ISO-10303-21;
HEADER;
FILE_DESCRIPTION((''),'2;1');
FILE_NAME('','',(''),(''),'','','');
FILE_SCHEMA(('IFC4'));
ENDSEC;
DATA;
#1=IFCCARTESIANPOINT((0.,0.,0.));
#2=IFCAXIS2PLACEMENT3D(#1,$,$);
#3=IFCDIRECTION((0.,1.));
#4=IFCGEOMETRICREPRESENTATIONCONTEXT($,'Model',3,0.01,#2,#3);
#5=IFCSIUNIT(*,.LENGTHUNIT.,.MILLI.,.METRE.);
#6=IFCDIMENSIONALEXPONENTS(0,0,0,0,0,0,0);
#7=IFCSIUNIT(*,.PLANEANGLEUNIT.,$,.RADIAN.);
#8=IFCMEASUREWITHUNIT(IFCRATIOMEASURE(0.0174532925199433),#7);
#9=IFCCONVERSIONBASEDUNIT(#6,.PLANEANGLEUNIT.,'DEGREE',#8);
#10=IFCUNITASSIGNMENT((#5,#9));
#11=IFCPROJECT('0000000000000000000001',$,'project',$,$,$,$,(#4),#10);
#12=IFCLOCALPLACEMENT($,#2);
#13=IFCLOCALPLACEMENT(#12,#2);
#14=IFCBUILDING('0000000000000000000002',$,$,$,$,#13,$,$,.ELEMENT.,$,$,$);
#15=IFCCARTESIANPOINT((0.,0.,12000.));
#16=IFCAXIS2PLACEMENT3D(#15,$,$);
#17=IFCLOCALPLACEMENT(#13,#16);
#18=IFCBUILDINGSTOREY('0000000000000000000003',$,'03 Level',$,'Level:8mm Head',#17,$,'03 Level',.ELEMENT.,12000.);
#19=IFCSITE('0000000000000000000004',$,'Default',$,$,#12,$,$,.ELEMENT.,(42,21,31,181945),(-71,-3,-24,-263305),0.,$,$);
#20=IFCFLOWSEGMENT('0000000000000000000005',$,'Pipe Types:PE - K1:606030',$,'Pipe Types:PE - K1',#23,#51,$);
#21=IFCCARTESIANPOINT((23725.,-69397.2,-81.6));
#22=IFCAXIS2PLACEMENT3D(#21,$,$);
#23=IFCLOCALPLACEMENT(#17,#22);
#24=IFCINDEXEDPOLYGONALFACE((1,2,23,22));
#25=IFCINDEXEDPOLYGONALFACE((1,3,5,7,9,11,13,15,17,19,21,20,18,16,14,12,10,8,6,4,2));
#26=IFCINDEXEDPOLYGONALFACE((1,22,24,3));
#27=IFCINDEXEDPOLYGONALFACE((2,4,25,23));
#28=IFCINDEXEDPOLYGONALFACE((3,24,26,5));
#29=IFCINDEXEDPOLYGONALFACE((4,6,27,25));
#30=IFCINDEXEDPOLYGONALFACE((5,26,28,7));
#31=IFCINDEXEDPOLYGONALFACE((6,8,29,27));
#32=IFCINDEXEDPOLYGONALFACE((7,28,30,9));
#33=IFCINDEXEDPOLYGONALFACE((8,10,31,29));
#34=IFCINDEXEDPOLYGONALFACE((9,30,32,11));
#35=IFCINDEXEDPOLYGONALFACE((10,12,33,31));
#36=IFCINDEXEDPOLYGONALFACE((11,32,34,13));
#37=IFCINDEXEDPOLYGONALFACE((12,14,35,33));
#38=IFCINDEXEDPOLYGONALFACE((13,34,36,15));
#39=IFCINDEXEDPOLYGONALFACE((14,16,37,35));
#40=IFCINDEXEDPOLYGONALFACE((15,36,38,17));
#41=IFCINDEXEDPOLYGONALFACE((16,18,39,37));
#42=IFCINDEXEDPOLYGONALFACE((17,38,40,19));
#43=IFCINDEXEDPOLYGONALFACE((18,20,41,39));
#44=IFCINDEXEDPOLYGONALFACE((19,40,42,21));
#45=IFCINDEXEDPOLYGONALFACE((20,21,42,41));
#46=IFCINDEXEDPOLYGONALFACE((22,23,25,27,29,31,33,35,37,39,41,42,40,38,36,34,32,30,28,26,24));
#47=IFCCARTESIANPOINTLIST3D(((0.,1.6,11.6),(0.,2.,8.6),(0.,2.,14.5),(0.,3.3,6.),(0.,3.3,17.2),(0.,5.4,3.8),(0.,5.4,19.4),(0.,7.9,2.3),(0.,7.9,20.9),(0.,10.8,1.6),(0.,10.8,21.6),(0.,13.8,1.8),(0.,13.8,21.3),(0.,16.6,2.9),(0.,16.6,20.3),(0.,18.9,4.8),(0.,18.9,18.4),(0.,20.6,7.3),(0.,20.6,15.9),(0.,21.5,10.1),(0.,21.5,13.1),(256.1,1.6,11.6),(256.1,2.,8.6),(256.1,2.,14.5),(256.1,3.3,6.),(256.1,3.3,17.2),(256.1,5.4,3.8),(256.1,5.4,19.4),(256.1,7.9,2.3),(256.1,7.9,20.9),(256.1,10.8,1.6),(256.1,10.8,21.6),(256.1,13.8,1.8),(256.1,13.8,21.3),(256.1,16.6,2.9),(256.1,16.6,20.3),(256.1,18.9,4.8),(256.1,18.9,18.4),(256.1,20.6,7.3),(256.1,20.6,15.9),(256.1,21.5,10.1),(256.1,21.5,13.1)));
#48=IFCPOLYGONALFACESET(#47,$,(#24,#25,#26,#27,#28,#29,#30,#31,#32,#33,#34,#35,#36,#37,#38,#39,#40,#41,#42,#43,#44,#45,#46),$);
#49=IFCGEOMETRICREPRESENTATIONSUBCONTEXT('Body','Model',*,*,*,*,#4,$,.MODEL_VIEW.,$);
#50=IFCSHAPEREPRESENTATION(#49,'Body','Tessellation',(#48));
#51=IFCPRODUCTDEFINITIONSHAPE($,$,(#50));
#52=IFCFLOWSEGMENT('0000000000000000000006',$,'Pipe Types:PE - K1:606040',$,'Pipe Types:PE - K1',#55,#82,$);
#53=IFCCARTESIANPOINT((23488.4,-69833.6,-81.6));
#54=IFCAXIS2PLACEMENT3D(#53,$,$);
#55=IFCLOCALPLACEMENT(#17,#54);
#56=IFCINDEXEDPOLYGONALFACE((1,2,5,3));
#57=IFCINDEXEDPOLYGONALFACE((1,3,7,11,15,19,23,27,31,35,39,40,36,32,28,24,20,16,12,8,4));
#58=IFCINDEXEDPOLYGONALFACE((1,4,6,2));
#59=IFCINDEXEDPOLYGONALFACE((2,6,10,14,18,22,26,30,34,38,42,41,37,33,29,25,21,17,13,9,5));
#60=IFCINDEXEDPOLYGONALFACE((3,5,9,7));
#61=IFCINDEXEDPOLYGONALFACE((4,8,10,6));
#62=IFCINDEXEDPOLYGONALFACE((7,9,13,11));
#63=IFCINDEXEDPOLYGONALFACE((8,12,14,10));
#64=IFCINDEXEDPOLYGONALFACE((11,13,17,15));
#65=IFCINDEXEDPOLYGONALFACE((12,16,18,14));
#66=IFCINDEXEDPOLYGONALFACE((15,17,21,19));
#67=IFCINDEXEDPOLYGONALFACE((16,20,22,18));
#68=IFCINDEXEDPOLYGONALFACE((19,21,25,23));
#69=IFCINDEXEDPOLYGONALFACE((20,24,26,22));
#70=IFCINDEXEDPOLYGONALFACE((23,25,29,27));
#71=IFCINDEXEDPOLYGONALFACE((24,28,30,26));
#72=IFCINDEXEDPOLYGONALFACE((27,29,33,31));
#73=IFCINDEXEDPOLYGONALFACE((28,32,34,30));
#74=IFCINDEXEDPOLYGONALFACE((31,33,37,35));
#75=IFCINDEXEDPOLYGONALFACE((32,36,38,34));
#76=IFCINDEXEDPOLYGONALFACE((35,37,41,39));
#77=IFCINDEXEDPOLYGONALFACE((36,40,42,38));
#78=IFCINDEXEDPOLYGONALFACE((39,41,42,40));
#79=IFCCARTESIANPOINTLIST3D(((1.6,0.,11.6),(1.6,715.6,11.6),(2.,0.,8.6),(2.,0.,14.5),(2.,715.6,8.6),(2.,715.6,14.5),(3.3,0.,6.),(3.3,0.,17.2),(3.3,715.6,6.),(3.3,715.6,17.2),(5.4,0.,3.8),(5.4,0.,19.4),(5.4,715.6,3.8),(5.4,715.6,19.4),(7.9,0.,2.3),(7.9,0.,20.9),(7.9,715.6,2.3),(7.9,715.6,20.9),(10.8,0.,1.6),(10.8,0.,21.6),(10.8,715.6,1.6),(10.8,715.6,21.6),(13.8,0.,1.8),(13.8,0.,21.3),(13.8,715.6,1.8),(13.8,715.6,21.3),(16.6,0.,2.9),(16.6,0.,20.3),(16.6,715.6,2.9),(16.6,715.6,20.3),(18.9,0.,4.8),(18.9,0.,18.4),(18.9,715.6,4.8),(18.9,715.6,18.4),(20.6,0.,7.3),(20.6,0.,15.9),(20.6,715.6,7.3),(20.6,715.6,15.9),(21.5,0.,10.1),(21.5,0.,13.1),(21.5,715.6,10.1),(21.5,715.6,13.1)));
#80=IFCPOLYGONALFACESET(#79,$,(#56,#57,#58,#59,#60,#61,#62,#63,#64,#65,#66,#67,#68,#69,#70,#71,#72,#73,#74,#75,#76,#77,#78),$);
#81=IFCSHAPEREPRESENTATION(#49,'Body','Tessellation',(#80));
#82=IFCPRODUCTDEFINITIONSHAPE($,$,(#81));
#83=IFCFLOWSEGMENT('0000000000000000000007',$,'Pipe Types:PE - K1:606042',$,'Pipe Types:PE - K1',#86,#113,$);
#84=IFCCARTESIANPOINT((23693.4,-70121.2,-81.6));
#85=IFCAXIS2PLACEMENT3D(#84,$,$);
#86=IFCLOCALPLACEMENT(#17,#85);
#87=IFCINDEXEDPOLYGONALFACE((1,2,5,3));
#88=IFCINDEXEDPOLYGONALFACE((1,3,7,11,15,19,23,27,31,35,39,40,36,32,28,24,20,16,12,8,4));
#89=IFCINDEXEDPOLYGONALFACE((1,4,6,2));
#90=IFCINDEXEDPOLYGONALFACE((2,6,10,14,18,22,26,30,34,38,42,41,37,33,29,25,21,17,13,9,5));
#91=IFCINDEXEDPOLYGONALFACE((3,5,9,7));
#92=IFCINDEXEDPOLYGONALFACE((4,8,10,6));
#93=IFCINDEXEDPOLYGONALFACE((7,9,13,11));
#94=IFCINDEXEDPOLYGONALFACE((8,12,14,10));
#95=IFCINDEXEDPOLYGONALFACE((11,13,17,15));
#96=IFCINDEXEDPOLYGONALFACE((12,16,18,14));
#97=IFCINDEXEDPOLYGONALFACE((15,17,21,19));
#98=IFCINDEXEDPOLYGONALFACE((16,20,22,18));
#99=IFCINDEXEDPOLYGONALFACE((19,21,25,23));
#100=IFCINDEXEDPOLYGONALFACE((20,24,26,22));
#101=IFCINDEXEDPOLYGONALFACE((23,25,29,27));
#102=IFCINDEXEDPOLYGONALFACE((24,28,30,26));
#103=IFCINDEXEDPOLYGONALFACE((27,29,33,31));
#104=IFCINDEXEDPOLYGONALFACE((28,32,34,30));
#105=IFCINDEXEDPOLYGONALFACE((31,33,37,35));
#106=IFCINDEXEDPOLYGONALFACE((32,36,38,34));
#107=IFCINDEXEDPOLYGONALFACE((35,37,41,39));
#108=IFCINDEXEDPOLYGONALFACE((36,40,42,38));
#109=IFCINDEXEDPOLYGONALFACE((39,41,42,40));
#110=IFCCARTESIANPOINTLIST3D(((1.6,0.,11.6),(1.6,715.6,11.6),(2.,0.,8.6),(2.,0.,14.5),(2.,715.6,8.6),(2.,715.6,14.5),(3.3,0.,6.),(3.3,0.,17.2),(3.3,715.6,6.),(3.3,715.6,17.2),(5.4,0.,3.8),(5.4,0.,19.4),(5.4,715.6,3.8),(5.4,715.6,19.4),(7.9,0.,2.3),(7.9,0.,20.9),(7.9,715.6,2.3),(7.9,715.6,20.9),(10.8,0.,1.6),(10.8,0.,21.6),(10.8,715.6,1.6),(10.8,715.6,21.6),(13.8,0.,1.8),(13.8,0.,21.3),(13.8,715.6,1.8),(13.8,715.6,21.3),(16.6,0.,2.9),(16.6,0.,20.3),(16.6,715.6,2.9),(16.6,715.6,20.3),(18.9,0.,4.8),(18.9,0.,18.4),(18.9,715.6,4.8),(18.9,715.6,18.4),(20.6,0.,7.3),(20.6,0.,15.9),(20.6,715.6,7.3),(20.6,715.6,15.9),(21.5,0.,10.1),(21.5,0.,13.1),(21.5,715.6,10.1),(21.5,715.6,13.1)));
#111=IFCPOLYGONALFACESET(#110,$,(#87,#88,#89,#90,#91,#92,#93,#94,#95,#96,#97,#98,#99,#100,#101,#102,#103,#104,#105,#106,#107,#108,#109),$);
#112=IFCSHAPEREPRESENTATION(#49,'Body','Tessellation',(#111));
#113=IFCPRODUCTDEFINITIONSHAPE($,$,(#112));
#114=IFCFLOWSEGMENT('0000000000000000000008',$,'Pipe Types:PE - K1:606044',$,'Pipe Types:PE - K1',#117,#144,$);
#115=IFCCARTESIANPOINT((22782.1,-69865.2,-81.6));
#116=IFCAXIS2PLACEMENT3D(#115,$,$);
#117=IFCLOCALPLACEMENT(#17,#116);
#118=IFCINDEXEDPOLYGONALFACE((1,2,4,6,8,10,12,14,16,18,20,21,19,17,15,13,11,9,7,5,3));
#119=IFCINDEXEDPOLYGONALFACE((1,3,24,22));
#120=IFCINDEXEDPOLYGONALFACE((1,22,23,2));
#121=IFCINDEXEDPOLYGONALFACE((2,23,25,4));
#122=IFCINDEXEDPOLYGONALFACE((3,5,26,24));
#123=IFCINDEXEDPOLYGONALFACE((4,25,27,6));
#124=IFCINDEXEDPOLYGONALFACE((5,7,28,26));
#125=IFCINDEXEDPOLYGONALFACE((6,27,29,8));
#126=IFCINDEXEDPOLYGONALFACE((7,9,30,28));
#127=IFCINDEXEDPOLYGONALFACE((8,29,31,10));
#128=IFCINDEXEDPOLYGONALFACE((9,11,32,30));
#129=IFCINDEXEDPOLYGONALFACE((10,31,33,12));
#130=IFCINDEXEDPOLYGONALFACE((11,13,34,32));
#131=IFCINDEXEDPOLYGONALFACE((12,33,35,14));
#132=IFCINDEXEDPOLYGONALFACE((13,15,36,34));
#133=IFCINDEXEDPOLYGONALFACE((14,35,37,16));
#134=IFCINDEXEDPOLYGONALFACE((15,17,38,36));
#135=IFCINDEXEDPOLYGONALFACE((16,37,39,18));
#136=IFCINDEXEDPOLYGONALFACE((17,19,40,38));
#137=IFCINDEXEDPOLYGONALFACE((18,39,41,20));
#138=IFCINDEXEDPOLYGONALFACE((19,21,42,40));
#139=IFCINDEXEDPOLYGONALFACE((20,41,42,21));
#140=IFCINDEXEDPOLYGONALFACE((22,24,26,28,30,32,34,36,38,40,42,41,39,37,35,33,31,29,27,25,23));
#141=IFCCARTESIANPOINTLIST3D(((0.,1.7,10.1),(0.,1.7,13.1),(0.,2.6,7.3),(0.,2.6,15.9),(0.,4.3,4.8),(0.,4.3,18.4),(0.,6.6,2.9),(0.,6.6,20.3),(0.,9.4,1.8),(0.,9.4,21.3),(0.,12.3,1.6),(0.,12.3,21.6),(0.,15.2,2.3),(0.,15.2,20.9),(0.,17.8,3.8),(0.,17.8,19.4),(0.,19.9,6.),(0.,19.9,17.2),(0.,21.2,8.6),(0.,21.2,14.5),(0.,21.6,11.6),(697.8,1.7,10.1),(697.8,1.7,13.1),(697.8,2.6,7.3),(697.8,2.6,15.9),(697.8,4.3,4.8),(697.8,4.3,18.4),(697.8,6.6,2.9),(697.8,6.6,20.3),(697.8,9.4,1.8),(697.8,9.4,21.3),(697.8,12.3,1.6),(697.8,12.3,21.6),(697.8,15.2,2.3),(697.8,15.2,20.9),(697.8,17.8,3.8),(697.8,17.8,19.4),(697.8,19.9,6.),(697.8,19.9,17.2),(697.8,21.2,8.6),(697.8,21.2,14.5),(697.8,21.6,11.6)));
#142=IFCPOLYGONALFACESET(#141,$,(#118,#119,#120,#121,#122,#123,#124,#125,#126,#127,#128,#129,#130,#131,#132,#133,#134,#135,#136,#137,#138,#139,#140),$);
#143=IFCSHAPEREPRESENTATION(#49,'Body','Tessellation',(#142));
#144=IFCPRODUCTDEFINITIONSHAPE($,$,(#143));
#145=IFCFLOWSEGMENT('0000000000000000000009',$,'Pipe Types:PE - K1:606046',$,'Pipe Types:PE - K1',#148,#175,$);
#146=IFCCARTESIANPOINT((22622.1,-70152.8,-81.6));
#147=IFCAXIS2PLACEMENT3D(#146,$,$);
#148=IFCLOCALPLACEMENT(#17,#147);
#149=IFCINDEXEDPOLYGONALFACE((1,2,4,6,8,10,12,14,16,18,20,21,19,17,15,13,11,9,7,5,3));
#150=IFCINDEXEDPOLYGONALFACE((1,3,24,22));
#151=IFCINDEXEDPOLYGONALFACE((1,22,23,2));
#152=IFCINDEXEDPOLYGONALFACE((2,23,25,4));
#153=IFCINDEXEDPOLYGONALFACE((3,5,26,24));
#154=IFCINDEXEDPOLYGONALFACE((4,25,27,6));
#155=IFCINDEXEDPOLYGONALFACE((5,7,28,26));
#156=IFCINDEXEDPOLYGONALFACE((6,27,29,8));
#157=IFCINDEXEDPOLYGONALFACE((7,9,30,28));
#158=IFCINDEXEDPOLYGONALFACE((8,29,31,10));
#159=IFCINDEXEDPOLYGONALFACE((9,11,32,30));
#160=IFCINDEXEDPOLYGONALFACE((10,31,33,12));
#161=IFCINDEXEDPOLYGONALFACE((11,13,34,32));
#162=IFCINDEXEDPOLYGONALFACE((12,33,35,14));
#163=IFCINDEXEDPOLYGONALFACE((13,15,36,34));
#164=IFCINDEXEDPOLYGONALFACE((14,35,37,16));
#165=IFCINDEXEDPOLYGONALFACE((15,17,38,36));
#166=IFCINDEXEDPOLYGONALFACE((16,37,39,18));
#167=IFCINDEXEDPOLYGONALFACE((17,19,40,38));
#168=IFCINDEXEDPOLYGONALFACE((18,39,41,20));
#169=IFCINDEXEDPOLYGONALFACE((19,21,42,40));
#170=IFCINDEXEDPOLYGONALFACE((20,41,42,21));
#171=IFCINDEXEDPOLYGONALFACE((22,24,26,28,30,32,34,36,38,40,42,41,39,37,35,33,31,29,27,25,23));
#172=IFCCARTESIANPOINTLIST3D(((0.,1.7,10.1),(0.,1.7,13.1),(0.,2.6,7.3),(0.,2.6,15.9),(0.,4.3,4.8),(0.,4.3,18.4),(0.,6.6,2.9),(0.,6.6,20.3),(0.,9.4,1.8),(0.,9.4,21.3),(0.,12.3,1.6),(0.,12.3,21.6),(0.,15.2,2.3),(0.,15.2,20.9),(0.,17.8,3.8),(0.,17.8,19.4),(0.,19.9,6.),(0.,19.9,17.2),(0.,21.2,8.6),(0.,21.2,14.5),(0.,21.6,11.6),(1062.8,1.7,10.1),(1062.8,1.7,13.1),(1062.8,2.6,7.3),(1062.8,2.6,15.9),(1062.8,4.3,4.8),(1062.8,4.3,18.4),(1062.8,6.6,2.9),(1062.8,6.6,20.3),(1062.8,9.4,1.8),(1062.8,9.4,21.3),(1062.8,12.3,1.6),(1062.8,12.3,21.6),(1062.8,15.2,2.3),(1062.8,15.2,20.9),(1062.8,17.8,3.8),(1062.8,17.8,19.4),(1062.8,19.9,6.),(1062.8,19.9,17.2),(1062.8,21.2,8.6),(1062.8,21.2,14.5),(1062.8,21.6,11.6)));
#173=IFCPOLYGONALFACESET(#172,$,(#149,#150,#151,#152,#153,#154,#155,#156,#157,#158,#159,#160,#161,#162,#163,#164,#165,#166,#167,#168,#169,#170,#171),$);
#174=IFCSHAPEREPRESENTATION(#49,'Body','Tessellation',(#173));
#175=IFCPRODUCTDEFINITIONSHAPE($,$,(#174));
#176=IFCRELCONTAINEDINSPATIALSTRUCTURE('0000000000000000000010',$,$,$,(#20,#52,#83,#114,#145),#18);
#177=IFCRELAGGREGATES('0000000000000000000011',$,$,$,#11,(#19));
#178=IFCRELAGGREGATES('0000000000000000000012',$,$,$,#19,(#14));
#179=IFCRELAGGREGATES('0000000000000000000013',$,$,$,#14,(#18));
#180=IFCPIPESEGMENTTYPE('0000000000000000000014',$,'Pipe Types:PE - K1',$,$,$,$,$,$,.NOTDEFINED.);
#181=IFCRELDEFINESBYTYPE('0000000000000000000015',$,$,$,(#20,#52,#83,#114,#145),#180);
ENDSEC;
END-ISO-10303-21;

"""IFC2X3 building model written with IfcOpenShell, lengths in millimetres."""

from ifc_helpers import new_model, entity, si_unit, converted_unit, direction, frame, frame_2d, origin, place, context, subcontext, project, spatial, circle, extrude, type_object, element, save


model = new_model("IFC2X3")

# Units and contexts
model_context = context("Model", 3, precision=0.01, world=origin(), true_north=direction((0.0, 1.0)))
body_context = subcontext(model_context, "Body", "Model", "MODEL_VIEW")
ifc_project = project(units=[si_unit("LENGTHUNIT", "METRE", prefix="MILLI"), converted_unit("PLANEANGLEUNIT", "DEGREE", entity("IfcRatioMeasure", 0.0174532925199433), si_unit("PLANEANGLEUNIT", "RADIAN"), dimensions=[0, 0, 0, 0, 0, 0, 0])], contexts=[model_context])

# Site, building, storey
site_placement = place(None, origin())
site = spatial("IfcSite", under=ifc_project, at=site_placement, Name="Default", CompositionType="ELEMENT", RefLatitude=(42, 21, 31, 181945), RefLongitude=(-71, -3, -24, -263305), RefElevation=0.0)
building_placement = place(site_placement, origin())
building = spatial("IfcBuilding", under=site, at=building_placement, CompositionType="ELEMENT")
storey_placement = place(building_placement, frame((0.0, 0.0, 12000.0)))
storey = spatial("IfcBuildingStorey", under=building, at=storey_placement, Name="03 Level", ObjectType="Level:8mm Head", LongName="03 Level", CompositionType="ELEMENT", Elevation=12000.0)

# Flow segments
pipe_segment_type = type_object("IfcPipeSegmentType", Name="Pipe Types:PE - K1", PredefinedType="NOTDEFINED")
flow_segment_1_placement = place(storey_placement, frame((23725.0, -69397.2, -81.6)))
element("IfcFlowSegment", 1, at=flow_segment_1_placement, inside=storey, type_object=pipe_segment_type, Name="Pipe Types:PE - K1:606030", ObjectType="Pipe Types:PE - K1", context=body_context, shape_type="SweptSolid", body=[
    extrude(circle(Radius=10.0, at=frame_2d((0.0, 0.0), x_axis=(1.0, 0.0))), frame((0.0, 11.6, 11.6), z_axis=(1.0, 0.0, 0.0), x_axis=(0.0, -1.0, 0.0)), (0.0, 0.0, 1.0), 256.1),
])
for number, where, name in (
    (2, (23488.4, -69833.6, -81.6), "Pipe Types:PE - K1:606040"),
    (3, (23693.4, -70121.2, -81.6), "Pipe Types:PE - K1:606042"),
):
    element("IfcFlowSegment", number, at=place(storey_placement, frame(where)), inside=storey, type_object=pipe_segment_type, Name=name, ObjectType="Pipe Types:PE - K1", context=body_context, shape_type="SweptSolid", body=[
        extrude(circle(Radius=10.0, at=frame_2d((0.0, 0.0), x_axis=(1.0, 0.0))), frame((11.6, 0.0, 11.6), z_axis=(0.0, 1.0, 0.0), x_axis=(-1.0, 0.0, 0.0)), (0.0, 0.0, 1.0), 715.6),
    ])
flow_segment_2_placement = place(storey_placement, frame((22782.1, -69865.2, -81.6)))
element("IfcFlowSegment", 4, at=flow_segment_2_placement, inside=storey, type_object=pipe_segment_type, Name="Pipe Types:PE - K1:606044", ObjectType="Pipe Types:PE - K1", context=body_context, shape_type="SweptSolid", body=[
    extrude(circle(Radius=10.0, at=frame_2d((0.0, 0.0), x_axis=(1.0, 0.0))), frame((0.0, 11.6, 11.6), z_axis=(1.0, 0.0, 0.0), x_axis=(0.0, 1.0, 0.0)), (0.0, 0.0, 1.0), 697.8),
])
flow_segment_3_placement = place(storey_placement, frame((22622.1, -70152.8, -81.6)))
element("IfcFlowSegment", 5, at=flow_segment_3_placement, inside=storey, type_object=pipe_segment_type, Name="Pipe Types:PE - K1:606046", ObjectType="Pipe Types:PE - K1", context=body_context, shape_type="SweptSolid", body=[
    extrude(circle(Radius=10.0, at=frame_2d((0.0, 0.0), x_axis=(1.0, 0.0))), frame((0.0, 11.6, 11.6), z_axis=(1.0, 0.0, 0.0), x_axis=(0.0, 1.0, 0.0)), (0.0, 0.0, 1.0), 1062.8),
])

save(model, "model.ifc")
